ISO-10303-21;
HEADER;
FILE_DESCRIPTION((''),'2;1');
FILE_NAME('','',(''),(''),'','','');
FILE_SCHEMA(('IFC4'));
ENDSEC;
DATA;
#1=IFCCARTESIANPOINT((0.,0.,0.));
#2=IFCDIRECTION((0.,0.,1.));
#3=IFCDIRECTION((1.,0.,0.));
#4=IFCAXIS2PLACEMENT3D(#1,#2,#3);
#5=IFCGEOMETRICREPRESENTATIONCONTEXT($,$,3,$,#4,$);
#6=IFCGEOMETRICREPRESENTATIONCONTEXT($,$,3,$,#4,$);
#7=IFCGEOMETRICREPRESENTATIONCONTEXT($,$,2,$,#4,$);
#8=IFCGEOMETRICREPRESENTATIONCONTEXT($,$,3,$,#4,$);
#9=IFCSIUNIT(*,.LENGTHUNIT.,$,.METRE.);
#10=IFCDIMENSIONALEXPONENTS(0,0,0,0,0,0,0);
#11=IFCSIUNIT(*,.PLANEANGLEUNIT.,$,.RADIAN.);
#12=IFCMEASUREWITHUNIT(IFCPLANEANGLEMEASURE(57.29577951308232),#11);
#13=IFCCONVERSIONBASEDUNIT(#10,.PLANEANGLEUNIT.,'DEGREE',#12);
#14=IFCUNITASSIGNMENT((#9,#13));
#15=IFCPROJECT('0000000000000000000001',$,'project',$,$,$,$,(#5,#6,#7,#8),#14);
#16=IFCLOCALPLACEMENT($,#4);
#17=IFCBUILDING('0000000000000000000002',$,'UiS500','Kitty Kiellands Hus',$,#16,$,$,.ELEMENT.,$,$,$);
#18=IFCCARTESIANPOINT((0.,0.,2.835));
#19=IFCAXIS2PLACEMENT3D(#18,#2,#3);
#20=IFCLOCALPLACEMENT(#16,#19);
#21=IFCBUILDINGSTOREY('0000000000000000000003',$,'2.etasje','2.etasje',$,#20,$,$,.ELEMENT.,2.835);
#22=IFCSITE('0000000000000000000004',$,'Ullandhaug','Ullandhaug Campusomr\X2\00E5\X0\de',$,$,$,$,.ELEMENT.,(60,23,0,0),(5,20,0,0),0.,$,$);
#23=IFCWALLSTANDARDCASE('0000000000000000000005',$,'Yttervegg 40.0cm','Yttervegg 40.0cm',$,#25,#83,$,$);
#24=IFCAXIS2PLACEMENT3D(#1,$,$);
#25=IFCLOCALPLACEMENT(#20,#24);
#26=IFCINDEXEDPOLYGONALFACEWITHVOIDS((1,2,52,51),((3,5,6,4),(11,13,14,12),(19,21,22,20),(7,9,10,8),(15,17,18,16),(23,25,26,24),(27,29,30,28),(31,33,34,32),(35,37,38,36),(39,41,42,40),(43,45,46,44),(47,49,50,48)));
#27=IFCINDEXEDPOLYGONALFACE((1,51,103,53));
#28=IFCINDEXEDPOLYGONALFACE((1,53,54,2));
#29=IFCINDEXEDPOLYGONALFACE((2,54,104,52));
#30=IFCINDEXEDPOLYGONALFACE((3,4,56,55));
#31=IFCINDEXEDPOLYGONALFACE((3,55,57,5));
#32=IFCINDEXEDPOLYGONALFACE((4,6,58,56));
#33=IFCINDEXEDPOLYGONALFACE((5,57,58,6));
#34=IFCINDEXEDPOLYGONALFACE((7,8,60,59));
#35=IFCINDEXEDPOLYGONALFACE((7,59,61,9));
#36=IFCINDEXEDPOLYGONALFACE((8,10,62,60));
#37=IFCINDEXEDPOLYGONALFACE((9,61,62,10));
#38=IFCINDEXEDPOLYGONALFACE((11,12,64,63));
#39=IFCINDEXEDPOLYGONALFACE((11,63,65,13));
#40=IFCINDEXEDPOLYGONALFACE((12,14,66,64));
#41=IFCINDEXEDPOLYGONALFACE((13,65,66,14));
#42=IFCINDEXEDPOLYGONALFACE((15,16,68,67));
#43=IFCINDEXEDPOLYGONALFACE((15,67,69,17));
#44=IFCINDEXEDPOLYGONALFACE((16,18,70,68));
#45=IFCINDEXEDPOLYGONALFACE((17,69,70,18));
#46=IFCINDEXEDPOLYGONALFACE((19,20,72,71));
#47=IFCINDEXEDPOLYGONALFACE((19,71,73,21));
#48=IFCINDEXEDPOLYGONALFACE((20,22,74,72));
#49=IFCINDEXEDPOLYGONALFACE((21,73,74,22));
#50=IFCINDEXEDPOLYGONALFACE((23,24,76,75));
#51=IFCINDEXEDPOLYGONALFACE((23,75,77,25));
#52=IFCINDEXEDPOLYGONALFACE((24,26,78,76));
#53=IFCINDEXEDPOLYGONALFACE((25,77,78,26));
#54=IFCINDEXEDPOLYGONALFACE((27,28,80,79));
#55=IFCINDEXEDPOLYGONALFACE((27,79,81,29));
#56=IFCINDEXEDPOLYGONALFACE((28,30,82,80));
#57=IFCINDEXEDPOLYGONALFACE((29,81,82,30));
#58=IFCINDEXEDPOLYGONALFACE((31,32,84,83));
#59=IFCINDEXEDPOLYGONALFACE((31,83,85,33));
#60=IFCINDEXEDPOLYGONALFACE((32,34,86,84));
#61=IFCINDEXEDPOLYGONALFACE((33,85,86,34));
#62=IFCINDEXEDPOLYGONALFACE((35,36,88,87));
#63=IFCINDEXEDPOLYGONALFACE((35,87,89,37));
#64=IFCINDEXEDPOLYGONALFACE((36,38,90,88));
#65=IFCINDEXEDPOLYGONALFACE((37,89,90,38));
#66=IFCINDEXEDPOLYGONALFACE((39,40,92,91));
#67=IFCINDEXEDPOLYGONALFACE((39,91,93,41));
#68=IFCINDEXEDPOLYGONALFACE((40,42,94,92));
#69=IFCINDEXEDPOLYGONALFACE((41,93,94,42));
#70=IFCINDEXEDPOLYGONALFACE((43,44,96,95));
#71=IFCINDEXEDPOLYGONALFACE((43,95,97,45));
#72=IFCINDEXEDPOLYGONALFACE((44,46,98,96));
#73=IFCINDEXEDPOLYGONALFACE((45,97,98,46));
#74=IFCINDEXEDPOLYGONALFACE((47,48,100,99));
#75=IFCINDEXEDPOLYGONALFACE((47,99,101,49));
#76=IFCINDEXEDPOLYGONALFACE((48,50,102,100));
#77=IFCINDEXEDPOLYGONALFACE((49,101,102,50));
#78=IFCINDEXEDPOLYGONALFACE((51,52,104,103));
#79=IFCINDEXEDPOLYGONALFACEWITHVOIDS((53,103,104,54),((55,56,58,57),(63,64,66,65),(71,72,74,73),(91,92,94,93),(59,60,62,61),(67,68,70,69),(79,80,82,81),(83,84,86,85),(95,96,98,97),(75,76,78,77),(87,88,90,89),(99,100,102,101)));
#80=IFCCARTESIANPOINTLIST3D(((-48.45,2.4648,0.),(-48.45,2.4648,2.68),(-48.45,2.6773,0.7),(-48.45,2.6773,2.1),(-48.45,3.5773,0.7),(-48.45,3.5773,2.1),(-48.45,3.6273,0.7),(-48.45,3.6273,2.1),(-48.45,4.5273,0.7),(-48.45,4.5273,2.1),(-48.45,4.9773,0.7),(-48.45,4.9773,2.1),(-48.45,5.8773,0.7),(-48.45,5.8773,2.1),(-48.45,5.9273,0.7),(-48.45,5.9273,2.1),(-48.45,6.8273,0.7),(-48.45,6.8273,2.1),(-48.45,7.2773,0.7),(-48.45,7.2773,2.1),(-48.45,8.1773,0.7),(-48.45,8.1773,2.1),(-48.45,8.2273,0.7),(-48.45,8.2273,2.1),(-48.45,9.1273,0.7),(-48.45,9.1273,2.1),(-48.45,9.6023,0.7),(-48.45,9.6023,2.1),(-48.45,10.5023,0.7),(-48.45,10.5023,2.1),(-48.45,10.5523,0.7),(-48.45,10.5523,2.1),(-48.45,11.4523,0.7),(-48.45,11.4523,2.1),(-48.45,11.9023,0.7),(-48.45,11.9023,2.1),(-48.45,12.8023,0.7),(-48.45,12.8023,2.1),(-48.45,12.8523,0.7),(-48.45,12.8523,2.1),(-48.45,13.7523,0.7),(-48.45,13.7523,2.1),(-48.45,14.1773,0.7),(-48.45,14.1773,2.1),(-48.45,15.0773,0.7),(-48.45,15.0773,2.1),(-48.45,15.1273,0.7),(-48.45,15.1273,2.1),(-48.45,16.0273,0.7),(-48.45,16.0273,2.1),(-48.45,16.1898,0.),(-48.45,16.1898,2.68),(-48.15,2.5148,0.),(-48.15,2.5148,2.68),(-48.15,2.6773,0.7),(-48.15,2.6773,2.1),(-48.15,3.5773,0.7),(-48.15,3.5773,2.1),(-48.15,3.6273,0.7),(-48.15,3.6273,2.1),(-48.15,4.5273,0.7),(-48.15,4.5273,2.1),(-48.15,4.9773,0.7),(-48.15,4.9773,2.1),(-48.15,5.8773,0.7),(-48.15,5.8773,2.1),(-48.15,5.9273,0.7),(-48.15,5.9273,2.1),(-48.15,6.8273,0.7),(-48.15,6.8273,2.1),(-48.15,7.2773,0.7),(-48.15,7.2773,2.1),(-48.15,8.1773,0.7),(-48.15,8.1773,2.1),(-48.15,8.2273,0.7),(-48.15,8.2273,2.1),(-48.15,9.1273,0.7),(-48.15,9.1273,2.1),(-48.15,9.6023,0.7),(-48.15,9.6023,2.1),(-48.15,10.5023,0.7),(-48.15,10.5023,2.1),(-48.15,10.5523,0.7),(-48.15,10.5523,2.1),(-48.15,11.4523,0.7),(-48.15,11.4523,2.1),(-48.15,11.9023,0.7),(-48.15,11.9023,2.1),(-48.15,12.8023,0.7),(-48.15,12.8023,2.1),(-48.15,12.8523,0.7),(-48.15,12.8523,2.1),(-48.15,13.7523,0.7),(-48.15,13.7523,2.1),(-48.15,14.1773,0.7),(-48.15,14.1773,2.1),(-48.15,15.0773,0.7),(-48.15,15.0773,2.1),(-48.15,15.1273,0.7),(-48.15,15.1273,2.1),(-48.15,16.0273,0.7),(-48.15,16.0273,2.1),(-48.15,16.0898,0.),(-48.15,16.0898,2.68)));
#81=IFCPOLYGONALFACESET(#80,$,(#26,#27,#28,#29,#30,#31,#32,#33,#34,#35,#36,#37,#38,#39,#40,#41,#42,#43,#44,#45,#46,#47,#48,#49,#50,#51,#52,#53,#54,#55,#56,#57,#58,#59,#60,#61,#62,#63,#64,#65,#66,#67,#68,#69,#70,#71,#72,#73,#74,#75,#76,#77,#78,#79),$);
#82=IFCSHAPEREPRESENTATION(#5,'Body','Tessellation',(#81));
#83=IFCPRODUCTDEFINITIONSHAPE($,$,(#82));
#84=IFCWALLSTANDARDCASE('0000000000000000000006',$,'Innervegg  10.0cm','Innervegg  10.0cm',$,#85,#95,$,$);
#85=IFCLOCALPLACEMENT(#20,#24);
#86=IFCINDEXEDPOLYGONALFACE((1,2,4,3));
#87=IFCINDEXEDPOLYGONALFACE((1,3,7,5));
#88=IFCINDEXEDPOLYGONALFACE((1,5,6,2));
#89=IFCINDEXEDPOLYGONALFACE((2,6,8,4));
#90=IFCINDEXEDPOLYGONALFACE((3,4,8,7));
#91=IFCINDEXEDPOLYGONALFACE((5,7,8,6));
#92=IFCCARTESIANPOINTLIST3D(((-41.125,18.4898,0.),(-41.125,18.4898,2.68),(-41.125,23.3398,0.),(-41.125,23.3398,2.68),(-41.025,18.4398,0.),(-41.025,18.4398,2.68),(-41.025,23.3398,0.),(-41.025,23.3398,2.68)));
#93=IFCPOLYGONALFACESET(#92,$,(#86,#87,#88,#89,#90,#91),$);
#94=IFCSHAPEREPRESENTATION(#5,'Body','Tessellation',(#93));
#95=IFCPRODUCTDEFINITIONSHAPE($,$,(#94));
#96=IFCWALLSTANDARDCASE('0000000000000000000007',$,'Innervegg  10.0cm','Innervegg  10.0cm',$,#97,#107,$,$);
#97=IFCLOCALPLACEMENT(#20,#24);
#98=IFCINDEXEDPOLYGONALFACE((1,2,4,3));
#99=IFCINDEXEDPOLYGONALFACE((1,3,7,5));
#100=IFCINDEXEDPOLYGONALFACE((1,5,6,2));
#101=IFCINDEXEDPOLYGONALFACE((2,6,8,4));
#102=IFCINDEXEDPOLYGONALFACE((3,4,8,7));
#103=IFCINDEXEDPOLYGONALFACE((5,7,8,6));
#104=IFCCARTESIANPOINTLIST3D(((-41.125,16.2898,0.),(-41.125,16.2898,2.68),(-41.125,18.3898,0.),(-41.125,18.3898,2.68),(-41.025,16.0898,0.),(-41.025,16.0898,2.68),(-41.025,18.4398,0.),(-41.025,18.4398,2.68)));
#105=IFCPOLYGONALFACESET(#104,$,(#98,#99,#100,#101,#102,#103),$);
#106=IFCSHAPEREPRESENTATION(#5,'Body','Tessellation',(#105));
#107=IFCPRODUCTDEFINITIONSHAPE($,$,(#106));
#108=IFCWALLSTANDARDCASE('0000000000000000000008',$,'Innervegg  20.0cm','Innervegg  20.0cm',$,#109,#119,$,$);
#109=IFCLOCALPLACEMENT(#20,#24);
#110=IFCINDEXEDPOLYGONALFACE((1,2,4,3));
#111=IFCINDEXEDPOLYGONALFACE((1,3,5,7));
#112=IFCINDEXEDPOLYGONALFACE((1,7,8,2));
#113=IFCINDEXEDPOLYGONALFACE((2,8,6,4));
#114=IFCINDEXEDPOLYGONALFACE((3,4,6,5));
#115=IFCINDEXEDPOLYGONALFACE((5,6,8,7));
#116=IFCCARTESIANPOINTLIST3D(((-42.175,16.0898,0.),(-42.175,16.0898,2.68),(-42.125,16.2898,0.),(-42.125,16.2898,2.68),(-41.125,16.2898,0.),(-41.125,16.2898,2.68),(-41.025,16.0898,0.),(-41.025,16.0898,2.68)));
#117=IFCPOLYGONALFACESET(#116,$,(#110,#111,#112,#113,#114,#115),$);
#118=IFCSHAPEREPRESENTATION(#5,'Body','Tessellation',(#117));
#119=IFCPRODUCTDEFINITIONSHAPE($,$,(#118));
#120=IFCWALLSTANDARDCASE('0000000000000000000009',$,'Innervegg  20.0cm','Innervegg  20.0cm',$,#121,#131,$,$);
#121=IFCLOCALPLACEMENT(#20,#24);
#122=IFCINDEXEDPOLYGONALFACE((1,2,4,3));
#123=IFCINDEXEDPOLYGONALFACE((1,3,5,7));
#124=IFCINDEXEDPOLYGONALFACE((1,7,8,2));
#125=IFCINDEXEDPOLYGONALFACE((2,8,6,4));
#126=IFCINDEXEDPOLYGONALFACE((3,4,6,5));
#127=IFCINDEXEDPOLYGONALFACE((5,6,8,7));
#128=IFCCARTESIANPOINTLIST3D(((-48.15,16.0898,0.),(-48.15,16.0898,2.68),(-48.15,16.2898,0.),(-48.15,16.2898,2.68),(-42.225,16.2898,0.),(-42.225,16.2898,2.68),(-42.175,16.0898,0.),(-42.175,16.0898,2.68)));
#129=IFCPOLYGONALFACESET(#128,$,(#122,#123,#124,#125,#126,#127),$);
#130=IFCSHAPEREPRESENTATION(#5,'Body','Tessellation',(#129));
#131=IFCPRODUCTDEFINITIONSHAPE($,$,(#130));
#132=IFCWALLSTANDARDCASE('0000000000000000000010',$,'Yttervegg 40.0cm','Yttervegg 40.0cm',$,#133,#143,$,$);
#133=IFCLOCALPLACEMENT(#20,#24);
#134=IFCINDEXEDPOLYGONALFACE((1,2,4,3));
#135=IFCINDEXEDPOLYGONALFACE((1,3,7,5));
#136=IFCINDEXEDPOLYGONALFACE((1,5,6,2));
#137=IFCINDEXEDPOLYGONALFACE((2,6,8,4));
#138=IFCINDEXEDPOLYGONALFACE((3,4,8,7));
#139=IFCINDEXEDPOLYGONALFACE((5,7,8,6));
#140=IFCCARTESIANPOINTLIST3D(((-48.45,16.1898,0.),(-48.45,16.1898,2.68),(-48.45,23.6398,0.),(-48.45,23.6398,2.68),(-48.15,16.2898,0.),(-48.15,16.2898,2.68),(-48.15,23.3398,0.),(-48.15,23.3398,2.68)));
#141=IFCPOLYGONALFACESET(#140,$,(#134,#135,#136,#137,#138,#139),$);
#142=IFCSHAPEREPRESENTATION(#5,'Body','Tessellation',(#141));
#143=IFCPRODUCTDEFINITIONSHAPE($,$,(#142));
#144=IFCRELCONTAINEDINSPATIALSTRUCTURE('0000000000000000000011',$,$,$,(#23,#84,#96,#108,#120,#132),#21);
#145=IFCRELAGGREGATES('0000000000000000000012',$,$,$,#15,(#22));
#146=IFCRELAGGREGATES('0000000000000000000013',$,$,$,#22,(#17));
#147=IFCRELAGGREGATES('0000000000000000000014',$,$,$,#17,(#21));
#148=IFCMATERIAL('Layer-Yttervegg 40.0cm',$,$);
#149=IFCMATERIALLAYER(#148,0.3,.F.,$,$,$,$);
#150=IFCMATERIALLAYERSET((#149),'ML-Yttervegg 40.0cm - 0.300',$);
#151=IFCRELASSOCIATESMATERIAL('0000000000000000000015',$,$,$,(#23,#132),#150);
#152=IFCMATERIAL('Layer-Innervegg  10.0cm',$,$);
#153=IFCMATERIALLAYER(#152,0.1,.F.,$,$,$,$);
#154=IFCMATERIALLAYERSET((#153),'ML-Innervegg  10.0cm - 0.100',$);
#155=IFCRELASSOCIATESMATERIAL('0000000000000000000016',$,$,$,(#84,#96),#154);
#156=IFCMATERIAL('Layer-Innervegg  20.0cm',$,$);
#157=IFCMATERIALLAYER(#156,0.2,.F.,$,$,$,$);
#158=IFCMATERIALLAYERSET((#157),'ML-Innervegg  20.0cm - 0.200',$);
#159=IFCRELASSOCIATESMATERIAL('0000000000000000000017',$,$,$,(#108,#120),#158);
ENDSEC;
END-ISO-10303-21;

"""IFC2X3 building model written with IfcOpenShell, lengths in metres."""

from ifc_helpers import new_model, entity, si_unit, converted_unit, frame, origin_with_axes, place, context, project, spatial, polyline, outline, extrude, material, layer, layer_set, layer_usage, element, save


model = new_model("IFC2X3")

# Units and contexts
context_of_model_1 = context(None, 3, world=origin_with_axes())
context_of_model_2 = context(None, 3, world=origin_with_axes())
context_of_model_3 = context(None, 2, world=origin_with_axes())
context_of_model_4 = context(None, 3, world=origin_with_axes())
ifc_project = project(units=[si_unit("LENGTHUNIT", "METRE"), converted_unit("PLANEANGLEUNIT", "DEGREE", entity("IfcPlaneAngleMeasure", 57.29577951308232), si_unit("PLANEANGLEUNIT", "RADIAN"), dimensions=[0, 0, 0, 0, 0, 0, 0])], contexts=[context_of_model_1, context_of_model_2, context_of_model_3, context_of_model_4])

# Site, building, storey
site = spatial("IfcSite", under=ifc_project, Name="Ullandhaug", Description="Ullandhaug Campusområde", CompositionType="ELEMENT", RefLatitude=(60, 23, 0, 0), RefLongitude=(5, 20, 0, 0), RefElevation=0.0)
building_placement = place(None, origin_with_axes())
building = spatial("IfcBuilding", under=site, at=building_placement, Name="UiS500", Description="Kitty Kiellands Hus", CompositionType="ELEMENT")
storey_placement = place(building_placement, frame((0.0, 0.0, 2.835), z_axis=(0.0, 0.0, 1.0), x_axis=(1.0, 0.0, 0.0)))
storey = spatial("IfcBuildingStorey", under=building, at=storey_placement, Name="2.etasje", Description="2.etasje", CompositionType="ELEMENT", Elevation=2.835)

# Wall, openings
ifc_material_1 = material(Name="Layer-Yttervegg 40.0cm")
ifc_layer_1 = layer(ifc_material_1, 0.3, ventilated=False)
ifc_layer_set_1 = layer_set([ifc_layer_1], Name="ML-Yttervegg 40.0cm - 0.300")
ifc_layer_usage_1 = layer_usage(ifc_layer_set_1, "AXIS2", "POSITIVE", 0.0)
wall_1_placement = place(storey_placement, frame((-48.45, 16.1898, 0.0), z_axis=(0.0, 0.0, 1.0), x_axis=(0.0, -1.0, 0.0)))
wall_1 = element("IfcWallStandardCase", 1, at=wall_1_placement, inside=storey, material=ifc_layer_usage_1, Name="Yttervegg 40.0cm", Description="Yttervegg 40.0cm", context=context_of_model_1, shape_type="SweptSolid", body=[
    extrude(outline(polyline([(0.0, 0.0), (13.725, 0.0), (13.675, 0.3), (0.1, 0.3), (0.0, 0.0)])), frame((0.0, 0.0, 0.0), z_axis=(0.0, 0.0, 1.0), x_axis=(1.0, 0.0, 0.0)), (0.0, 0.0, 1.0), 2.68),
])
opening_1_placement = place(wall_1_placement, frame((12.6125, 0.3, 0.7), z_axis=(0.0, 0.0, 1.0), x_axis=(1.0, 0.0, 0.0)))
element("IfcOpeningElement", 2, at=opening_1_placement, cuts=wall_1, context=context_of_model_1, shape_type="SweptSolid", body=[
    extrude(outline(polyline([(0.0, 0.0), (1.4, 0.0), (1.4, 0.9), (0.0, 0.9), (0.0, 0.0)])), frame((0.0, 0.0, 0.0), z_axis=(0.0, 1.0, 0.0), x_axis=(0.0, 0.0, 1.0)), (0.0, 0.0, -1.0), 0.3),
])
opening_2_placement = place(wall_1_placement, frame((11.6625, 0.3, 0.7), z_axis=(0.0, 0.0, 1.0), x_axis=(1.0, 0.0, 0.0)))
element("IfcOpeningElement", 3, at=opening_2_placement, cuts=wall_1, context=context_of_model_1, shape_type="SweptSolid", body=[
    extrude(outline(polyline([(0.0, 0.0), (1.4, 0.0), (1.4, 0.9), (0.0, 0.9), (0.0, 0.0)])), frame((0.0, 0.0, 0.0), z_axis=(0.0, 1.0, 0.0), x_axis=(0.0, 0.0, 1.0)), (0.0, 0.0, -1.0), 0.3),
])
opening_3_placement = place(wall_1_placement, frame((10.3125, 0.3, 0.7), z_axis=(0.0, 0.0, 1.0), x_axis=(1.0, 0.0, 0.0)))
element("IfcOpeningElement", 4, at=opening_3_placement, cuts=wall_1, context=context_of_model_1, shape_type="SweptSolid", body=[
    extrude(outline(polyline([(0.0, 0.0), (1.4, 0.0), (1.4, 0.9), (0.0, 0.9), (0.0, 0.0)])), frame((0.0, 0.0, 0.0), z_axis=(0.0, 1.0, 0.0), x_axis=(0.0, 0.0, 1.0)), (0.0, 0.0, -1.0), 0.3),
])
opening_4_placement = place(wall_1_placement, frame((9.3625, 0.3, 0.7), z_axis=(0.0, 0.0, 1.0), x_axis=(1.0, 0.0, 0.0)))
element("IfcOpeningElement", 5, at=opening_4_placement, cuts=wall_1, context=context_of_model_1, shape_type="SweptSolid", body=[
    extrude(outline(polyline([(0.0, 0.0), (1.4, 0.0), (1.4, 0.9), (0.0, 0.9), (0.0, 0.0)])), frame((0.0, 0.0, 0.0), z_axis=(0.0, 1.0, 0.0), x_axis=(0.0, 0.0, 1.0)), (0.0, 0.0, -1.0), 0.3),
])
opening_5_placement = place(wall_1_placement, frame((8.0125, 0.3, 0.7), z_axis=(0.0, 0.0, 1.0), x_axis=(1.0, 0.0, 0.0)))
element("IfcOpeningElement", 6, at=opening_5_placement, cuts=wall_1, context=context_of_model_1, shape_type="SweptSolid", body=[
    extrude(outline(polyline([(0.0, 0.0), (1.4, 0.0), (1.4, 0.9), (0.0, 0.9), (0.0, 0.0)])), frame((0.0, 0.0, 0.0), z_axis=(0.0, 1.0, 0.0), x_axis=(0.0, 0.0, 1.0)), (0.0, 0.0, -1.0), 0.3),
])
opening_6_placement = place(wall_1_placement, frame((7.0625, 0.3, 0.7), z_axis=(0.0, 0.0, 1.0), x_axis=(1.0, 0.0, 0.0)))
element("IfcOpeningElement", 7, at=opening_6_placement, cuts=wall_1, context=context_of_model_1, shape_type="SweptSolid", body=[
    extrude(outline(polyline([(0.0, 0.0), (1.4, 0.0), (1.4, 0.9), (0.0, 0.9), (0.0, 0.0)])), frame((0.0, 0.0, 0.0), z_axis=(0.0, 1.0, 0.0), x_axis=(0.0, 0.0, 1.0)), (0.0, 0.0, -1.0), 0.3),
])
opening_7_placement = place(wall_1_placement, frame((5.6875, 0.3, 0.7), z_axis=(0.0, 0.0, 1.0), x_axis=(1.0, 0.0, 0.0)))
element("IfcOpeningElement", 8, at=opening_7_placement, cuts=wall_1, context=context_of_model_1, shape_type="SweptSolid", body=[
    extrude(outline(polyline([(0.0, 0.0), (1.4, 0.0), (1.4, 0.9), (0.0, 0.9), (0.0, 0.0)])), frame((0.0, 0.0, 0.0), z_axis=(0.0, 1.0, 0.0), x_axis=(0.0, 0.0, 1.0)), (0.0, 0.0, -1.0), 0.3),
])
opening_8_placement = place(wall_1_placement, frame((4.7375, 0.3, 0.7), z_axis=(0.0, 0.0, 1.0), x_axis=(1.0, 0.0, 0.0)))
element("IfcOpeningElement", 9, at=opening_8_placement, cuts=wall_1, context=context_of_model_1, shape_type="SweptSolid", body=[
    extrude(outline(polyline([(0.0, 0.0), (1.4, 0.0), (1.4, 0.9), (0.0, 0.9), (0.0, 0.0)])), frame((0.0, 0.0, 0.0), z_axis=(0.0, 1.0, 0.0), x_axis=(0.0, 0.0, 1.0)), (0.0, 0.0, -1.0), 0.3),
])
opening_9_placement = place(wall_1_placement, frame((3.3875, 0.3, 0.7), z_axis=(0.0, 0.0, 1.0), x_axis=(1.0, 0.0, 0.0)))
element("IfcOpeningElement", 10, at=opening_9_placement, cuts=wall_1, context=context_of_model_1, shape_type="SweptSolid", body=[
    extrude(outline(polyline([(0.0, 0.0), (1.4, 0.0), (1.4, 0.9), (0.0, 0.9), (0.0, 0.0)])), frame((0.0, 0.0, 0.0), z_axis=(0.0, 1.0, 0.0), x_axis=(0.0, 0.0, 1.0)), (0.0, 0.0, -1.0), 0.3),
])
opening_10_placement = place(wall_1_placement, frame((2.4375, 0.3, 0.7), z_axis=(0.0, 0.0, 1.0), x_axis=(1.0, 0.0, 0.0)))
element("IfcOpeningElement", 11, at=opening_10_placement, cuts=wall_1, context=context_of_model_1, shape_type="SweptSolid", body=[
    extrude(outline(polyline([(0.0, 0.0), (1.4, 0.0), (1.4, 0.9), (0.0, 0.9), (0.0, 0.0)])), frame((0.0, 0.0, 0.0), z_axis=(0.0, 1.0, 0.0), x_axis=(0.0, 0.0, 1.0)), (0.0, 0.0, -1.0), 0.3),
])
opening_11_placement = place(wall_1_placement, frame((1.1125, 0.3, 0.7), z_axis=(0.0, 0.0, 1.0), x_axis=(1.0, 0.0, 0.0)))
element("IfcOpeningElement", 12, at=opening_11_placement, cuts=wall_1, context=context_of_model_1, shape_type="SweptSolid", body=[
    extrude(outline(polyline([(0.0, 0.0), (1.4, 0.0), (1.4, 0.9), (0.0, 0.9), (0.0, 0.0)])), frame((0.0, 0.0, 0.0), z_axis=(0.0, 1.0, 0.0), x_axis=(0.0, 0.0, 1.0)), (0.0, 0.0, -1.0), 0.3),
])
opening_12_placement = place(wall_1_placement, frame((0.1625, 0.3, 0.7), z_axis=(0.0, 0.0, 1.0), x_axis=(1.0, 0.0, 0.0)))
element("IfcOpeningElement", 13, at=opening_12_placement, cuts=wall_1, context=context_of_model_1, shape_type="SweptSolid", body=[
    extrude(outline(polyline([(0.0, 0.0), (1.4, 0.0), (1.4, 0.9), (0.0, 0.9), (0.0, 0.0)])), frame((0.0, 0.0, 0.0), z_axis=(0.0, 1.0, 0.0), x_axis=(0.0, 0.0, 1.0)), (0.0, 0.0, -1.0), 0.3),
])

# Walls
ifc_material_2 = material(Name="Layer-Innervegg  10.0cm")
ifc_layer_2 = layer(ifc_material_2, 0.1, ventilated=False)
ifc_layer_set_2 = layer_set([ifc_layer_2], Name="ML-Innervegg  10.0cm - 0.100")
ifc_layer_usage_2 = layer_usage(ifc_layer_set_2, "AXIS2", "POSITIVE", 0.0)
wall_2_placement = place(storey_placement, frame((-41.125, 23.3398, 0.0), z_axis=(0.0, 0.0, 1.0), x_axis=(0.0, -1.0, 0.0)))
element("IfcWallStandardCase", 14, at=wall_2_placement, inside=storey, material=ifc_layer_usage_2, Name="Innervegg  10.0cm", Description="Innervegg  10.0cm", context=context_of_model_1, shape_type="SweptSolid", body=[
    extrude(outline(polyline([(0.0, 0.0), (4.85, 0.0), (4.9, 0.1), (0.0, 0.1), (0.0, 0.0)])), frame((0.0, 0.0, 0.0), z_axis=(0.0, 0.0, 1.0), x_axis=(1.0, 0.0, 0.0)), (0.0, 0.0, 1.0), 2.68),
])
wall_3_placement = place(storey_placement, frame((-41.125, 18.3898, 0.0), z_axis=(0.0, 0.0, 1.0), x_axis=(0.0, -1.0, 0.0)))
element("IfcWallStandardCase", 15, at=wall_3_placement, inside=storey, material=ifc_layer_usage_2, Name="Innervegg  10.0cm", Description="Innervegg  10.0cm", context=context_of_model_1, shape_type="SweptSolid", body=[
    extrude(outline(polyline([(0.0, 0.0), (2.1, 0.0), (2.3, 0.1), (-0.05, 0.1), (0.0, 0.0)])), frame((0.0, 0.0, 0.0), z_axis=(0.0, 0.0, 1.0), x_axis=(1.0, 0.0, 0.0)), (0.0, 0.0, 1.0), 2.68),
])
ifc_material_3 = material(Name="Layer-Innervegg  20.0cm")
ifc_layer_3 = layer(ifc_material_3, 0.2, ventilated=False)
ifc_layer_set_3 = layer_set([ifc_layer_3], Name="ML-Innervegg  20.0cm - 0.200")
ifc_layer_usage_3 = layer_usage(ifc_layer_set_3, "AXIS2", "POSITIVE", 0.0)
wall_4_placement = place(storey_placement, frame((-41.125, 16.2898, 0.0), z_axis=(0.0, 0.0, 1.0), x_axis=(-1.0, 0.0, 0.0)))
element("IfcWallStandardCase", 16, at=wall_4_placement, inside=storey, material=ifc_layer_usage_3, Name="Innervegg  20.0cm", Description="Innervegg  20.0cm", context=context_of_model_1, shape_type="SweptSolid", body=[
    extrude(outline(polyline([(0.0, 0.0), (1.0, 0.0), (1.05, 0.2), (-0.1, 0.2), (0.0, 0.0)])), frame((0.0, 0.0, 0.0), z_axis=(0.0, 0.0, 1.0), x_axis=(1.0, 0.0, 0.0)), (0.0, 0.0, 1.0), 2.68),
])
wall_5_placement = place(storey_placement, frame((-42.225, 16.2898, 0.0), z_axis=(0.0, 0.0, 1.0), x_axis=(-1.0, 0.0, 0.0)))
element("IfcWallStandardCase", 17, at=wall_5_placement, inside=storey, material=ifc_layer_usage_3, Name="Innervegg  20.0cm", Description="Innervegg  20.0cm", context=context_of_model_1, shape_type="SweptSolid", body=[
    extrude(outline(polyline([(0.0, 0.0), (5.925, 0.0), (5.925, 0.2), (-0.05, 0.2), (0.0, 0.0)])), frame((0.0, 0.0, 0.0), z_axis=(0.0, 0.0, 1.0), x_axis=(1.0, 0.0, 0.0)), (0.0, 0.0, 1.0), 2.68),
])
wall_6_placement = place(storey_placement, frame((-48.45, 23.6398, 0.0), z_axis=(0.0, 0.0, 1.0), x_axis=(0.0, -1.0, 0.0)))
element("IfcWallStandardCase", 18, at=wall_6_placement, inside=storey, material=ifc_layer_usage_1, Name="Yttervegg 40.0cm", Description="Yttervegg 40.0cm", context=context_of_model_1, shape_type="SweptSolid", body=[
    extrude(outline(polyline([(0.0, 0.0), (7.45, 0.0), (7.35, 0.3), (0.3, 0.3), (0.0, 0.0)])), frame((0.0, 0.0, 0.0), z_axis=(0.0, 0.0, 1.0), x_axis=(1.0, 0.0, 0.0)), (0.0, 0.0, 1.0), 2.68),
])

save(model, "model.ifc")
